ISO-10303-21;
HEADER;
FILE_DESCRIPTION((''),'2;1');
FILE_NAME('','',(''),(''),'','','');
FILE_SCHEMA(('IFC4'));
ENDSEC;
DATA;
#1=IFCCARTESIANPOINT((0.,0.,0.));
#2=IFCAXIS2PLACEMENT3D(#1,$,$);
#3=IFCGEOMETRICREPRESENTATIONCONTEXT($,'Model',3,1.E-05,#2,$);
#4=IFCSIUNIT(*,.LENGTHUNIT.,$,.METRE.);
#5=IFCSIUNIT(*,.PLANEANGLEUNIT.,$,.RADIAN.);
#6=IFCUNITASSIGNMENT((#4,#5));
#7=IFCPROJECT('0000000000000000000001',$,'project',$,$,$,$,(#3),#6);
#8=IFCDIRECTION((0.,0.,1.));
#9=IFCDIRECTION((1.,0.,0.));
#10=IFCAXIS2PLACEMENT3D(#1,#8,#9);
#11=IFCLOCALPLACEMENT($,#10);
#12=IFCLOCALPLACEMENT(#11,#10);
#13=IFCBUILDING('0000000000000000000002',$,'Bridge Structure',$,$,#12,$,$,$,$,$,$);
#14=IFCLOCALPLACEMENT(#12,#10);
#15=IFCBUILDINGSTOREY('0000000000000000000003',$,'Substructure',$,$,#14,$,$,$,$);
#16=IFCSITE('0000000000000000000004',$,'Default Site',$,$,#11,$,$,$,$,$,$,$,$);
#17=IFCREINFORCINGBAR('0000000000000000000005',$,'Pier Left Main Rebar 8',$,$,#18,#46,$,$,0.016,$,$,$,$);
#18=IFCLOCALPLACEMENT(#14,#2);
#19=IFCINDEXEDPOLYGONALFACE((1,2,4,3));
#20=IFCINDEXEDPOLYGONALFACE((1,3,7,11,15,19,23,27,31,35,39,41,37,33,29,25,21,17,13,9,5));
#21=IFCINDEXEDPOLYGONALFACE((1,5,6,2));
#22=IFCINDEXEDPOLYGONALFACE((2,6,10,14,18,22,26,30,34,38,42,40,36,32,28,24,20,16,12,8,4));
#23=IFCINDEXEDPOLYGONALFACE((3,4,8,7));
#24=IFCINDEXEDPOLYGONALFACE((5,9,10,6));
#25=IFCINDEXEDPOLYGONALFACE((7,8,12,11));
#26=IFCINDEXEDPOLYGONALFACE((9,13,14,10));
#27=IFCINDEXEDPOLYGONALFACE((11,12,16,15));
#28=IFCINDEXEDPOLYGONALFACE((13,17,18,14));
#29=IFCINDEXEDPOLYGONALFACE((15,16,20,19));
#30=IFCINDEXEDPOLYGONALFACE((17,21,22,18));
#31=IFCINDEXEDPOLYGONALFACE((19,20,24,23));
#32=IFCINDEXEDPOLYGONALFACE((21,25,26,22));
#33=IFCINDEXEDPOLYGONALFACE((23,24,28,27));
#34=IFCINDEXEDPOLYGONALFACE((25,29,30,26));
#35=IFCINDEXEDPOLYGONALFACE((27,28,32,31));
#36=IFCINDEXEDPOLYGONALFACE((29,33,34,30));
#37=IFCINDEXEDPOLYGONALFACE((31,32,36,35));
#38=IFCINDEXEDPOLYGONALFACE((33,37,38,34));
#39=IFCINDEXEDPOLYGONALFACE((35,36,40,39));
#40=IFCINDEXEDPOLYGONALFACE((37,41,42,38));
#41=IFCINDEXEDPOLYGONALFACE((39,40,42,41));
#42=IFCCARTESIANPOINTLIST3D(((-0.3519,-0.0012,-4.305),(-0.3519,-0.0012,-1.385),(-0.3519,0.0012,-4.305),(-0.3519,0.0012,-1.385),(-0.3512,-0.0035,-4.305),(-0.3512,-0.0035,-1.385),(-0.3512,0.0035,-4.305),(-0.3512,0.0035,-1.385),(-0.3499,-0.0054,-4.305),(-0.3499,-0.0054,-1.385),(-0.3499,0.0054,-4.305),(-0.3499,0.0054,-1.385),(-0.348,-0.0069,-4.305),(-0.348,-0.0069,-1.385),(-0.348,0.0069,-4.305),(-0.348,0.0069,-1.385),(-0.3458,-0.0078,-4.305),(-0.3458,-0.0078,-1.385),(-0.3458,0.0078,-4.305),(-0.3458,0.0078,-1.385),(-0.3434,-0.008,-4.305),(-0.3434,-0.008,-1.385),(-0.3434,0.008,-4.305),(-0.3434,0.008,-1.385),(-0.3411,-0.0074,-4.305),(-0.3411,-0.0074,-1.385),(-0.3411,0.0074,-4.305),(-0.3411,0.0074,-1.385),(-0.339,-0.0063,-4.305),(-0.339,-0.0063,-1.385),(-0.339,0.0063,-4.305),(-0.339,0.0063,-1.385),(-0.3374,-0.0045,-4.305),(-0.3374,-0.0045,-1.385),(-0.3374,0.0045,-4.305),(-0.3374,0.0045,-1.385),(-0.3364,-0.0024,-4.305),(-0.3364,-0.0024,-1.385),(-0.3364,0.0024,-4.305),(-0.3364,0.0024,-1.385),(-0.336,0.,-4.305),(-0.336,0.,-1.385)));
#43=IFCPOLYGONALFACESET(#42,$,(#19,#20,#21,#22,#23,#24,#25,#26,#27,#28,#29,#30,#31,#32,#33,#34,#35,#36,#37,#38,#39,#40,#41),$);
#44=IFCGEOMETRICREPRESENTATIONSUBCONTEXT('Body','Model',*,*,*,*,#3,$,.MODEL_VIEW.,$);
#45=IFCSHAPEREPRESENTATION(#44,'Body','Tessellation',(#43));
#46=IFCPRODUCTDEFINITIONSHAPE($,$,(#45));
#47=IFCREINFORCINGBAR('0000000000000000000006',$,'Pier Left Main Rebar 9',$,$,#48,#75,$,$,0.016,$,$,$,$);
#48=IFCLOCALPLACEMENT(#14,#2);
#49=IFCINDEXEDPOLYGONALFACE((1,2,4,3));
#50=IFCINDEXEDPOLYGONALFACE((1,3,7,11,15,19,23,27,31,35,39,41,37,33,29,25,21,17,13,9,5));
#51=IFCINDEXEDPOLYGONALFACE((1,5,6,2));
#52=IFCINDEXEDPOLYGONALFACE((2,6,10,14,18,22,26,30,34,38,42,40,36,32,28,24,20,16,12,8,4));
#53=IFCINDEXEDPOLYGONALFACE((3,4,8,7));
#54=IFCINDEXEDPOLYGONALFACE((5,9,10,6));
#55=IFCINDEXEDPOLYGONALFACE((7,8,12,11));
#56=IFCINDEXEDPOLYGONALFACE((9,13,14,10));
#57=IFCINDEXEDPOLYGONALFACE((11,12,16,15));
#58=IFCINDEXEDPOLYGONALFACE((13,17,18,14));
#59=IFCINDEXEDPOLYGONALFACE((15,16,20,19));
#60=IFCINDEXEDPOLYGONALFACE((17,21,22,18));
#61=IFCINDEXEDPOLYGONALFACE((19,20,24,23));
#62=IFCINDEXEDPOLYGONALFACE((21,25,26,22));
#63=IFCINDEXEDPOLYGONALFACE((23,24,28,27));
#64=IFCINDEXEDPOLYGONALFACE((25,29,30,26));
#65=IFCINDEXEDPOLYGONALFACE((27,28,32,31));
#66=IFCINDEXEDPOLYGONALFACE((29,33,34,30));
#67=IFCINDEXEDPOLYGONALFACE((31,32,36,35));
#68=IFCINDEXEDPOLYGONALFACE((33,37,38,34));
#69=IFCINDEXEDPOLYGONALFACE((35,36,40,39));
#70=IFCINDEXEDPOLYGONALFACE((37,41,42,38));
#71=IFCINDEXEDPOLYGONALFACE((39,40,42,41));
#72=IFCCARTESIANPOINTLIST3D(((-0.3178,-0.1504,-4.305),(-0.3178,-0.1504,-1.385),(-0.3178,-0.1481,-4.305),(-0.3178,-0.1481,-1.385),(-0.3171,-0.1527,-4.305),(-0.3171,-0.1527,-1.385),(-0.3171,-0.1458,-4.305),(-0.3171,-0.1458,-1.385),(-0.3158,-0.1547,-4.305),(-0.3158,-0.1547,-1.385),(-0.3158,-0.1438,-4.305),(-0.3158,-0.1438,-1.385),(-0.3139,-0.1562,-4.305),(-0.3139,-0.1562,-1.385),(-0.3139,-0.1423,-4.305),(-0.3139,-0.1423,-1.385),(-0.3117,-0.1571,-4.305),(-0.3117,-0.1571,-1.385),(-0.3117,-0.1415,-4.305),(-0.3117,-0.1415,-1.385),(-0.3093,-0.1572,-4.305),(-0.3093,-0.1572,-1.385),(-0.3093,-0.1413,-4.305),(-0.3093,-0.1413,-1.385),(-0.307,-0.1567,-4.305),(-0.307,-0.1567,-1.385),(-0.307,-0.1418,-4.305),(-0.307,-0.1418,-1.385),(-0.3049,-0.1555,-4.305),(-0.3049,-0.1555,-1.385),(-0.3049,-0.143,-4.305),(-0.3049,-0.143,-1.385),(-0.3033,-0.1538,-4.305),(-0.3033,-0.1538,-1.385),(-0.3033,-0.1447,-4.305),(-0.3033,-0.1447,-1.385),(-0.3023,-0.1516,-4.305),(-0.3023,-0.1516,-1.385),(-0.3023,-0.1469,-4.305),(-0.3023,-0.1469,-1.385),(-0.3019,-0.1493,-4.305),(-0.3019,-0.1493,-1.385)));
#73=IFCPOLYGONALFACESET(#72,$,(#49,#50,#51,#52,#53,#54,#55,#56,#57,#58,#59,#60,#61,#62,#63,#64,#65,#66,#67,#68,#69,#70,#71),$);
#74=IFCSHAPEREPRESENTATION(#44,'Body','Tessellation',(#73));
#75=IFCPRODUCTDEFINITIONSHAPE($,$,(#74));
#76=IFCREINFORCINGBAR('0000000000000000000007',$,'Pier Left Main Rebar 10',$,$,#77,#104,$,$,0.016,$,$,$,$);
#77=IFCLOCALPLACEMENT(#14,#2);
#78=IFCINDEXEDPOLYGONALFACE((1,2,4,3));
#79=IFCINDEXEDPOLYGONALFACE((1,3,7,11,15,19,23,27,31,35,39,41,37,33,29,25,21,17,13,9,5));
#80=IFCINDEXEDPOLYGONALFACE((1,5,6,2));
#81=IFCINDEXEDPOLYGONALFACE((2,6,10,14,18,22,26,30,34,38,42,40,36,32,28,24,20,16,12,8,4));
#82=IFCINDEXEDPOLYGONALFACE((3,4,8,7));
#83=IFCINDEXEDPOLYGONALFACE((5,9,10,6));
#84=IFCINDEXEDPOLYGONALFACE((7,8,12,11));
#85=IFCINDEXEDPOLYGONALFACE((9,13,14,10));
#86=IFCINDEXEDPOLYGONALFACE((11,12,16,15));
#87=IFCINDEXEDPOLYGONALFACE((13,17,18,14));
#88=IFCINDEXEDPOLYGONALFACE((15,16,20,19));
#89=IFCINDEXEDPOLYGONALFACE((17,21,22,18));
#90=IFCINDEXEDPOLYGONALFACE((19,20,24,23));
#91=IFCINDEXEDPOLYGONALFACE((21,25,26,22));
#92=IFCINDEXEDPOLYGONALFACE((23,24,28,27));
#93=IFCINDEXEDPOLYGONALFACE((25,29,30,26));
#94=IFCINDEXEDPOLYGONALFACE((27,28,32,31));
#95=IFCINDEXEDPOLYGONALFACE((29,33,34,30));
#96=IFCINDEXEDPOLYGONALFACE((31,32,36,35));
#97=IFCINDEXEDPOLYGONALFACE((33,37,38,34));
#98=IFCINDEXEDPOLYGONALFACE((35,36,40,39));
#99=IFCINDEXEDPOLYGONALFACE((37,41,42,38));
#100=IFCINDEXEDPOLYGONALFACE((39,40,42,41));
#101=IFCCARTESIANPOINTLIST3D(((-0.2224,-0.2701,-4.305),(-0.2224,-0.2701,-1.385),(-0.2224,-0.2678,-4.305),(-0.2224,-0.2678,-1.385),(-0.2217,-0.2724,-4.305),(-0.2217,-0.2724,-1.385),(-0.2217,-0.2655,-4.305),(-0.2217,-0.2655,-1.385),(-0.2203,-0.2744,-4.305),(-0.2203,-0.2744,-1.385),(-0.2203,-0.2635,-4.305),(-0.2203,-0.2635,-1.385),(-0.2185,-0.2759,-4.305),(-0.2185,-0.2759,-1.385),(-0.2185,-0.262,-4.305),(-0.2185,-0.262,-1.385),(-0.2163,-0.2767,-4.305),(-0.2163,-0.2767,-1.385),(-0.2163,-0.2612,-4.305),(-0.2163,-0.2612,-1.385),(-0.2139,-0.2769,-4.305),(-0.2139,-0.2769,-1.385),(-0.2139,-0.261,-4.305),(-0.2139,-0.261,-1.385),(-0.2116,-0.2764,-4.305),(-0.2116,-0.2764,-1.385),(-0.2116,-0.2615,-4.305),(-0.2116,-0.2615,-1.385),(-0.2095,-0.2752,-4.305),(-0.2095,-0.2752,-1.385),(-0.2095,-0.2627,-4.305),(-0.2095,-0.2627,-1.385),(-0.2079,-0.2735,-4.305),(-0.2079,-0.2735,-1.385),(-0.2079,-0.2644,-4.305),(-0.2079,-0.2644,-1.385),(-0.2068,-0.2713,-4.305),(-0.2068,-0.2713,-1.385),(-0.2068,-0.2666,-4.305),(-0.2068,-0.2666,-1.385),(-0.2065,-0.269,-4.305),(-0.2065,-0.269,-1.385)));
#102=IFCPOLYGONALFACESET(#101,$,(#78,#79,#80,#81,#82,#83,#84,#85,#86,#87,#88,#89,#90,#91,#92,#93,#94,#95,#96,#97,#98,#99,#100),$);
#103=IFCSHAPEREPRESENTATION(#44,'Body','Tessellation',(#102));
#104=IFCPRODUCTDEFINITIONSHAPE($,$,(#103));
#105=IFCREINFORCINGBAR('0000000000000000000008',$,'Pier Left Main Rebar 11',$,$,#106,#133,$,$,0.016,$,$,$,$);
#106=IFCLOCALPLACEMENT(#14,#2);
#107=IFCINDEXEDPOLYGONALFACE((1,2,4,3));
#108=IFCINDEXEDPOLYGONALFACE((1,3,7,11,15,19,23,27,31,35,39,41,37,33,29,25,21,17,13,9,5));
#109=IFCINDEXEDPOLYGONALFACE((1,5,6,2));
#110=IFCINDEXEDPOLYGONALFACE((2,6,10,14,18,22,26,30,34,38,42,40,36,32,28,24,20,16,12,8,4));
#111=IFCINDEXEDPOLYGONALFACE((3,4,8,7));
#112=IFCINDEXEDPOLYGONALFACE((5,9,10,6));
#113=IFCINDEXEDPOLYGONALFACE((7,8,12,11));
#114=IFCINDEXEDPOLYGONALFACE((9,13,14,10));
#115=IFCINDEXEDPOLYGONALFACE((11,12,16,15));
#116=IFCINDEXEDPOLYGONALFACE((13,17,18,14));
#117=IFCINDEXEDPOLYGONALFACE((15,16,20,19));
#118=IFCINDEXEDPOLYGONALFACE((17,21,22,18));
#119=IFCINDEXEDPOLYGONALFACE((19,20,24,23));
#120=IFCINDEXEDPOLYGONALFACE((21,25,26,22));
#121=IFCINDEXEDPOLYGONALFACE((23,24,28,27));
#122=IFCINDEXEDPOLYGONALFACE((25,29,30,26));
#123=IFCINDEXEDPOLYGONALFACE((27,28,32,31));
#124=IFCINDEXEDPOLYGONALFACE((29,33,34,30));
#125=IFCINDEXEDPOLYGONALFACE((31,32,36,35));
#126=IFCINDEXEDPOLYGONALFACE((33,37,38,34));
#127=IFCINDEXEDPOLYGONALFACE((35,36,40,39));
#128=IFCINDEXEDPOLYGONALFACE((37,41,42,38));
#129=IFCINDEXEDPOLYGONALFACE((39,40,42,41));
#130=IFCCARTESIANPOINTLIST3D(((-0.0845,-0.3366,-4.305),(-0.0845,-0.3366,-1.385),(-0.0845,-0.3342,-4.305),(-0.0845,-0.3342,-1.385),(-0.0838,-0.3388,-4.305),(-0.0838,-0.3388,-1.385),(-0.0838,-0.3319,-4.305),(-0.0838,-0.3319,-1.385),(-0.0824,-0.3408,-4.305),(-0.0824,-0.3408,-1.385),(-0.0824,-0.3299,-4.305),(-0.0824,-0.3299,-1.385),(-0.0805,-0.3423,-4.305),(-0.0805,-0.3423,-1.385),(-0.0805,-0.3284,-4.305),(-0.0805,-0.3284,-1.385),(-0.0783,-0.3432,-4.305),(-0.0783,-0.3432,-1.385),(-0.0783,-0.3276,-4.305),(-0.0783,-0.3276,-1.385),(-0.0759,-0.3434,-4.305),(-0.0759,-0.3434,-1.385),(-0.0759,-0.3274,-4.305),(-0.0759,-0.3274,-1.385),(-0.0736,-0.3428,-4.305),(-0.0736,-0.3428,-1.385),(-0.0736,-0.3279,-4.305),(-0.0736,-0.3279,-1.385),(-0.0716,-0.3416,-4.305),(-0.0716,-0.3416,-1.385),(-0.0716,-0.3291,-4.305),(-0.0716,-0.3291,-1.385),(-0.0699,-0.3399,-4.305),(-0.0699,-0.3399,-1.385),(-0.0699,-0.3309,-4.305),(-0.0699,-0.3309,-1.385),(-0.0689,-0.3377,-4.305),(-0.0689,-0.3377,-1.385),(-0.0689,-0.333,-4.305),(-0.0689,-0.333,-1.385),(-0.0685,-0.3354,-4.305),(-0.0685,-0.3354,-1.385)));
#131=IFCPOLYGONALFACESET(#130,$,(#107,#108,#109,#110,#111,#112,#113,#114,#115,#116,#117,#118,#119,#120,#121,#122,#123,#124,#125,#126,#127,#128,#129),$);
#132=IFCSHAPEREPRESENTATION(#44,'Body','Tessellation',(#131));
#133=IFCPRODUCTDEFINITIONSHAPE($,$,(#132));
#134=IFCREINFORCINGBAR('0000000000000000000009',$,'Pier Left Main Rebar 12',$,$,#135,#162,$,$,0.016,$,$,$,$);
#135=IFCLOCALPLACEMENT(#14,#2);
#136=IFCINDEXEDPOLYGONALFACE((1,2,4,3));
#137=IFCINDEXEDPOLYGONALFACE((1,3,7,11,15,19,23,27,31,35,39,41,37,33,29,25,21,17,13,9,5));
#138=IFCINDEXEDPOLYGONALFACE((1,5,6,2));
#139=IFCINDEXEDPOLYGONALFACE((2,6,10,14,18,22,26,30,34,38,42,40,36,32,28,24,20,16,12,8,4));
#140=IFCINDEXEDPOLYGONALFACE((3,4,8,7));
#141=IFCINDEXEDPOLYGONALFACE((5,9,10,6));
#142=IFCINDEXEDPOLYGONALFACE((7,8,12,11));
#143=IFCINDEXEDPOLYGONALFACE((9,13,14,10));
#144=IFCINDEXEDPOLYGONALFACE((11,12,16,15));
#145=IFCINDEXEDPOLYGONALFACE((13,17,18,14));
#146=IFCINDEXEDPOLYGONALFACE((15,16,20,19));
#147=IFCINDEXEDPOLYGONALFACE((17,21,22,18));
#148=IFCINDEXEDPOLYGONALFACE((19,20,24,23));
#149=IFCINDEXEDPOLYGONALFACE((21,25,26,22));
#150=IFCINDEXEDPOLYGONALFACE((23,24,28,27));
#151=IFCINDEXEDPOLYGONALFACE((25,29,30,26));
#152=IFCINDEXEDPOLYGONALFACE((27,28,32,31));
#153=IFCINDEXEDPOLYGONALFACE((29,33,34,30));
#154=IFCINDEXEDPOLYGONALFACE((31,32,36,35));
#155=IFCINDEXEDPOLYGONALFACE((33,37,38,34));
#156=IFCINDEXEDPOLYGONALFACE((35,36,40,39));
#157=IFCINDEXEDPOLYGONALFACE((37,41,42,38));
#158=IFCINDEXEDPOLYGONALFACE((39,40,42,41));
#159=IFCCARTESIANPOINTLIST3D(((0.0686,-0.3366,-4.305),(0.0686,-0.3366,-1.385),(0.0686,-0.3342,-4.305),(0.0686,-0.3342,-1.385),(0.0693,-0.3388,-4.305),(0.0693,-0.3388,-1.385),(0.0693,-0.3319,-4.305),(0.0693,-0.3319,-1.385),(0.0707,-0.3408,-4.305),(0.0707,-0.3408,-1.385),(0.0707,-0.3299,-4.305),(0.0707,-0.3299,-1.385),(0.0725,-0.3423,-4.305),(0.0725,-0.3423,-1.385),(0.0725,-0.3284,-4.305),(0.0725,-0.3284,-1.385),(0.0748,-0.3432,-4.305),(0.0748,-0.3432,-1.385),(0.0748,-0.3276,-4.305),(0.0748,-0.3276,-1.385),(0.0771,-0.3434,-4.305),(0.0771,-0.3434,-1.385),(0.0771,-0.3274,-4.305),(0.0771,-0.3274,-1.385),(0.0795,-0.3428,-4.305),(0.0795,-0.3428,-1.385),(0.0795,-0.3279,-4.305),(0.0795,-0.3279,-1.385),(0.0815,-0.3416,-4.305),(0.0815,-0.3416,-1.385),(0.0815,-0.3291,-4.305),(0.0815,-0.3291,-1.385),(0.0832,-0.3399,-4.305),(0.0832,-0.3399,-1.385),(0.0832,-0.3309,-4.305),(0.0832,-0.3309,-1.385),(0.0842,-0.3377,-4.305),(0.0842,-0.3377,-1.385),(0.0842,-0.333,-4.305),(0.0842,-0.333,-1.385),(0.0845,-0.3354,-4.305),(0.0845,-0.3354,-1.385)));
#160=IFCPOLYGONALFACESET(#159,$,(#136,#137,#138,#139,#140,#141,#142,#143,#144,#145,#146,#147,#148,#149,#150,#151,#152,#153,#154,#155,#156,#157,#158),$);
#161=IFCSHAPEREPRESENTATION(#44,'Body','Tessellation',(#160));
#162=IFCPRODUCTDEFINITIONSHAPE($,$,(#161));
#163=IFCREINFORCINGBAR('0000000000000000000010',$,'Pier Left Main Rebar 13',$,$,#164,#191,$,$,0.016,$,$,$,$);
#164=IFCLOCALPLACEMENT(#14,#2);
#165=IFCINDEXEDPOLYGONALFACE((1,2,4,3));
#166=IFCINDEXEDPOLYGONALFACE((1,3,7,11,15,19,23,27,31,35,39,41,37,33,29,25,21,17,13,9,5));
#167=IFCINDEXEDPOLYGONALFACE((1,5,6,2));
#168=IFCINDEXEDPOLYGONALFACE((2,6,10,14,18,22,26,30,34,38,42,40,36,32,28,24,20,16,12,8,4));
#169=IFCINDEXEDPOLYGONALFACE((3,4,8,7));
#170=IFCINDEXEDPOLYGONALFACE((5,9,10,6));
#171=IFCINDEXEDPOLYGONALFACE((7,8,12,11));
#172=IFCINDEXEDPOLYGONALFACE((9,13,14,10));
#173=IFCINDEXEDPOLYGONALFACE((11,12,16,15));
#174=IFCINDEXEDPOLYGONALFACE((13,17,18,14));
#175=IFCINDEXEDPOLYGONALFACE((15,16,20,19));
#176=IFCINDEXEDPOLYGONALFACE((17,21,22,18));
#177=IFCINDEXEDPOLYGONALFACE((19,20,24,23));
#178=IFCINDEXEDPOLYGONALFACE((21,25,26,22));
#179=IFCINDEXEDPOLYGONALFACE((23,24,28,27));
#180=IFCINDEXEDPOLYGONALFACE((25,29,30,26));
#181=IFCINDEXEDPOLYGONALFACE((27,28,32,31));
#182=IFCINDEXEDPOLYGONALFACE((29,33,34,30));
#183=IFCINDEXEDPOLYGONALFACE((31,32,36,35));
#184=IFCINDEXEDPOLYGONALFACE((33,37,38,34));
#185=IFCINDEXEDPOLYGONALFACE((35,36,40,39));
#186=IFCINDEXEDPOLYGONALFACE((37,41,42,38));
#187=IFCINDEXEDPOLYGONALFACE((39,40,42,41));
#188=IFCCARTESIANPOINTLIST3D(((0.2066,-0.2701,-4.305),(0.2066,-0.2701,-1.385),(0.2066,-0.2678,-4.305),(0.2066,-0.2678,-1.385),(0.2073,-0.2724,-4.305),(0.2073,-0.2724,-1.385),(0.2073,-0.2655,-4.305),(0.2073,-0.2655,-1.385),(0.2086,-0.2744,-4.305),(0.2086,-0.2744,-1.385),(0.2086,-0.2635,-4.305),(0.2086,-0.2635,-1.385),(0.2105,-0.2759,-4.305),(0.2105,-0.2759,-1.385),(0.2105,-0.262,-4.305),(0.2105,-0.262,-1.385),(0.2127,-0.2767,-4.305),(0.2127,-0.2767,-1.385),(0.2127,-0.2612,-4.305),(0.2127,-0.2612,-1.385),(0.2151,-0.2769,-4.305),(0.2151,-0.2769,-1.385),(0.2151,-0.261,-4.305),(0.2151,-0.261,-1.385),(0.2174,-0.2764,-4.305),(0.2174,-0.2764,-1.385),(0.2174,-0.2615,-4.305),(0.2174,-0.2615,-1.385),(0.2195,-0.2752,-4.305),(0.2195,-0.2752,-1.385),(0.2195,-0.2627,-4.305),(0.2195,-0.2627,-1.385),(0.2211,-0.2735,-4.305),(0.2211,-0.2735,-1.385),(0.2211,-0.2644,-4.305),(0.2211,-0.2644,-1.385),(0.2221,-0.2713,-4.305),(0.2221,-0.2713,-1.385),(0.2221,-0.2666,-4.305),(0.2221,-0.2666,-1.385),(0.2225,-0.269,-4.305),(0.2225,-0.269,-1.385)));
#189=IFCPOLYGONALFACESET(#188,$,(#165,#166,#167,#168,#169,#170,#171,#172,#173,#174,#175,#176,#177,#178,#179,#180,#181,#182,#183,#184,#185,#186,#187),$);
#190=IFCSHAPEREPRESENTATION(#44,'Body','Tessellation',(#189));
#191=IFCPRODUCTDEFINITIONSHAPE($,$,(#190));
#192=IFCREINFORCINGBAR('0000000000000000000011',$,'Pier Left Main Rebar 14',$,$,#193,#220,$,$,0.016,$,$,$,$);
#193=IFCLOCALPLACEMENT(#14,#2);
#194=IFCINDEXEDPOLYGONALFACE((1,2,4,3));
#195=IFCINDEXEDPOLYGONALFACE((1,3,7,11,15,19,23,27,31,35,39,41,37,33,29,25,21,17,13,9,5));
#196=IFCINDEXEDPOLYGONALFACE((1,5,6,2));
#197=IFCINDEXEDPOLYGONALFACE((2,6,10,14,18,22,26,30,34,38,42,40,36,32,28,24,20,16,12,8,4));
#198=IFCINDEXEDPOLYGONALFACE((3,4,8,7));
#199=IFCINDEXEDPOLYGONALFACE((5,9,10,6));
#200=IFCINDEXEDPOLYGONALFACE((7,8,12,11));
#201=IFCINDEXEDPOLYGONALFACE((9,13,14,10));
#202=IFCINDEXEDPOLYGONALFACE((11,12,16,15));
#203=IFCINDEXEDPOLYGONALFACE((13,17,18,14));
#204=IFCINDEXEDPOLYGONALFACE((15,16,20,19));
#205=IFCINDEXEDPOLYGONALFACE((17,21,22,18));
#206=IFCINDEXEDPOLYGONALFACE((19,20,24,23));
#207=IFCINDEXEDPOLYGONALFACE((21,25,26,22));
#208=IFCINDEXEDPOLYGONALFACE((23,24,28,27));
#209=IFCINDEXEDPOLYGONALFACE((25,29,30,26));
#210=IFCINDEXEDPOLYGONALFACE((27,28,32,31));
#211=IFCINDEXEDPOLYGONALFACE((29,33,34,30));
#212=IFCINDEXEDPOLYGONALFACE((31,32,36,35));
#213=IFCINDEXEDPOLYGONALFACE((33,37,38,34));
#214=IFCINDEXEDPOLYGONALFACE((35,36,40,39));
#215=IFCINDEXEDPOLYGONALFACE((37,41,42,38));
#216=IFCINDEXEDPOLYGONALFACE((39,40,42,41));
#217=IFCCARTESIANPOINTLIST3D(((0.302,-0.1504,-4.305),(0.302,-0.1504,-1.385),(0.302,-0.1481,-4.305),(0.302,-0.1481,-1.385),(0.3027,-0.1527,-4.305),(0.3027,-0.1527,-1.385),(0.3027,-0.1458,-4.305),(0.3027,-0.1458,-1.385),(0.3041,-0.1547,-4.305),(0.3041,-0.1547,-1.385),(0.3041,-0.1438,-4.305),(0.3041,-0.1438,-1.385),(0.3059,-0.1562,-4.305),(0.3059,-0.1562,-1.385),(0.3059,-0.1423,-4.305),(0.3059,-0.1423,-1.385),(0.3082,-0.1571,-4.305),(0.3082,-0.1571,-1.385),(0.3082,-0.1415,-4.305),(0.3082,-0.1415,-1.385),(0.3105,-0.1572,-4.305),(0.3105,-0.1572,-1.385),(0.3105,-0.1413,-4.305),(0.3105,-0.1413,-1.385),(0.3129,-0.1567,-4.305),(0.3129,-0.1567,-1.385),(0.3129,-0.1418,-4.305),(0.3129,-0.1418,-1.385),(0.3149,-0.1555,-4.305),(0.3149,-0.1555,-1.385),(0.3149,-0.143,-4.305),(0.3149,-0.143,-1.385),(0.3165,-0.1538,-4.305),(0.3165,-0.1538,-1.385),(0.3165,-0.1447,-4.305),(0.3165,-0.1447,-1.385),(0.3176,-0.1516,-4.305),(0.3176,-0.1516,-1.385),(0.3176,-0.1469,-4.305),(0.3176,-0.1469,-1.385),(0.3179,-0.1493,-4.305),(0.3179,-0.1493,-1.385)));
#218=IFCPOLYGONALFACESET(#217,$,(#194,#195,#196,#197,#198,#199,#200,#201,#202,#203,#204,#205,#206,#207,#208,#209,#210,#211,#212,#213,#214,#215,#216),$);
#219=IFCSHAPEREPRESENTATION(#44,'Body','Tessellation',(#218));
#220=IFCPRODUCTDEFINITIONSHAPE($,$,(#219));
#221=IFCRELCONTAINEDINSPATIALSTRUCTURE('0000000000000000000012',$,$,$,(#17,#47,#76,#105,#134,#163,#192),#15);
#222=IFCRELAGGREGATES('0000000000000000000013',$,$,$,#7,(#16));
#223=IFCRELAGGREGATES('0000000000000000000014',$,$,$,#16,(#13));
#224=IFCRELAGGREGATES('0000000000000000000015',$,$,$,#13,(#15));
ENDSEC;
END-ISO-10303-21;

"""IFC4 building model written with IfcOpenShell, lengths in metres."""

from ifc_helpers import new_model, si_unit, frame, origin, origin_with_axes, origin_2d_with_axis, place, context, subcontext, project, spatial, circle, extrude, element, save


model = new_model("IFC4")

# Units and contexts
model_context = context("Model", 3, precision=1e-05, world=origin())
body_context = subcontext(model_context, "Body", "Model", "MODEL_VIEW")
ifc_project = project(units=[si_unit("LENGTHUNIT", "METRE"), si_unit("PLANEANGLEUNIT", "RADIAN")], contexts=[model_context])

# Site, building, storey
site_placement = place(None, origin_with_axes())
site = spatial("IfcSite", under=ifc_project, at=site_placement, Name="Default Site")
building_placement = place(site_placement, origin_with_axes())
building = spatial("IfcBuilding", under=site, at=building_placement, Name="Bridge Structure")
storey_placement = place(building_placement, origin_with_axes())
storey = spatial("IfcBuildingStorey", under=building, at=storey_placement, Name="Substructure")

# Reinforcing bars
for number, where, z_axis, x_axis, name in (
    (1, (-0.344, 0.0, -4.305), (0.0, 0.0, 1.0), (1.0, 0.0, 0.0), "Pier Left Main Rebar 8"),
    (2, (-0.3099, -0.1493, -4.305), (0.0, 0.0, 1.0), (1.0, 0.0, 0.0), "Pier Left Main Rebar 9"),
    (3, (-0.2145, -0.269, -4.305), (0.0, 0.0, 1.0), (1.0, 0.0, 0.0), "Pier Left Main Rebar 10"),
    (4, (-0.0765, -0.3354, -4.305), (0.0, 0.0, 1.0), (1.0, 0.0, 0.0), "Pier Left Main Rebar 11"),
    (5, (0.0765, -0.3354, -4.305), (0.0, 0.0, 1.0), (1.0, 0.0, 0.0), "Pier Left Main Rebar 12"),
    (6, (0.2145, -0.269, -4.305), (0.0, 0.0, 1.0), (1.0, 0.0, 0.0), "Pier Left Main Rebar 13"),
    (7, (0.3099, -0.1493, -4.305), (0.0, 0.0, 1.0), (1.0, 0.0, 0.0), "Pier Left Main Rebar 14"),
):
    element("IfcReinforcingBar", number, at=place(storey_placement, frame(where, z_axis=z_axis, x_axis=x_axis)), inside=storey, Name=name, NominalDiameter=0.016, context=body_context, shape_type="SweptSolid", body=[
        extrude(circle(Radius=0.008, at=origin_2d_with_axis()), origin_with_axes(), (0.0, 0.0, 1.0), 2.92),
    ])

save(model, "model.ifc")
